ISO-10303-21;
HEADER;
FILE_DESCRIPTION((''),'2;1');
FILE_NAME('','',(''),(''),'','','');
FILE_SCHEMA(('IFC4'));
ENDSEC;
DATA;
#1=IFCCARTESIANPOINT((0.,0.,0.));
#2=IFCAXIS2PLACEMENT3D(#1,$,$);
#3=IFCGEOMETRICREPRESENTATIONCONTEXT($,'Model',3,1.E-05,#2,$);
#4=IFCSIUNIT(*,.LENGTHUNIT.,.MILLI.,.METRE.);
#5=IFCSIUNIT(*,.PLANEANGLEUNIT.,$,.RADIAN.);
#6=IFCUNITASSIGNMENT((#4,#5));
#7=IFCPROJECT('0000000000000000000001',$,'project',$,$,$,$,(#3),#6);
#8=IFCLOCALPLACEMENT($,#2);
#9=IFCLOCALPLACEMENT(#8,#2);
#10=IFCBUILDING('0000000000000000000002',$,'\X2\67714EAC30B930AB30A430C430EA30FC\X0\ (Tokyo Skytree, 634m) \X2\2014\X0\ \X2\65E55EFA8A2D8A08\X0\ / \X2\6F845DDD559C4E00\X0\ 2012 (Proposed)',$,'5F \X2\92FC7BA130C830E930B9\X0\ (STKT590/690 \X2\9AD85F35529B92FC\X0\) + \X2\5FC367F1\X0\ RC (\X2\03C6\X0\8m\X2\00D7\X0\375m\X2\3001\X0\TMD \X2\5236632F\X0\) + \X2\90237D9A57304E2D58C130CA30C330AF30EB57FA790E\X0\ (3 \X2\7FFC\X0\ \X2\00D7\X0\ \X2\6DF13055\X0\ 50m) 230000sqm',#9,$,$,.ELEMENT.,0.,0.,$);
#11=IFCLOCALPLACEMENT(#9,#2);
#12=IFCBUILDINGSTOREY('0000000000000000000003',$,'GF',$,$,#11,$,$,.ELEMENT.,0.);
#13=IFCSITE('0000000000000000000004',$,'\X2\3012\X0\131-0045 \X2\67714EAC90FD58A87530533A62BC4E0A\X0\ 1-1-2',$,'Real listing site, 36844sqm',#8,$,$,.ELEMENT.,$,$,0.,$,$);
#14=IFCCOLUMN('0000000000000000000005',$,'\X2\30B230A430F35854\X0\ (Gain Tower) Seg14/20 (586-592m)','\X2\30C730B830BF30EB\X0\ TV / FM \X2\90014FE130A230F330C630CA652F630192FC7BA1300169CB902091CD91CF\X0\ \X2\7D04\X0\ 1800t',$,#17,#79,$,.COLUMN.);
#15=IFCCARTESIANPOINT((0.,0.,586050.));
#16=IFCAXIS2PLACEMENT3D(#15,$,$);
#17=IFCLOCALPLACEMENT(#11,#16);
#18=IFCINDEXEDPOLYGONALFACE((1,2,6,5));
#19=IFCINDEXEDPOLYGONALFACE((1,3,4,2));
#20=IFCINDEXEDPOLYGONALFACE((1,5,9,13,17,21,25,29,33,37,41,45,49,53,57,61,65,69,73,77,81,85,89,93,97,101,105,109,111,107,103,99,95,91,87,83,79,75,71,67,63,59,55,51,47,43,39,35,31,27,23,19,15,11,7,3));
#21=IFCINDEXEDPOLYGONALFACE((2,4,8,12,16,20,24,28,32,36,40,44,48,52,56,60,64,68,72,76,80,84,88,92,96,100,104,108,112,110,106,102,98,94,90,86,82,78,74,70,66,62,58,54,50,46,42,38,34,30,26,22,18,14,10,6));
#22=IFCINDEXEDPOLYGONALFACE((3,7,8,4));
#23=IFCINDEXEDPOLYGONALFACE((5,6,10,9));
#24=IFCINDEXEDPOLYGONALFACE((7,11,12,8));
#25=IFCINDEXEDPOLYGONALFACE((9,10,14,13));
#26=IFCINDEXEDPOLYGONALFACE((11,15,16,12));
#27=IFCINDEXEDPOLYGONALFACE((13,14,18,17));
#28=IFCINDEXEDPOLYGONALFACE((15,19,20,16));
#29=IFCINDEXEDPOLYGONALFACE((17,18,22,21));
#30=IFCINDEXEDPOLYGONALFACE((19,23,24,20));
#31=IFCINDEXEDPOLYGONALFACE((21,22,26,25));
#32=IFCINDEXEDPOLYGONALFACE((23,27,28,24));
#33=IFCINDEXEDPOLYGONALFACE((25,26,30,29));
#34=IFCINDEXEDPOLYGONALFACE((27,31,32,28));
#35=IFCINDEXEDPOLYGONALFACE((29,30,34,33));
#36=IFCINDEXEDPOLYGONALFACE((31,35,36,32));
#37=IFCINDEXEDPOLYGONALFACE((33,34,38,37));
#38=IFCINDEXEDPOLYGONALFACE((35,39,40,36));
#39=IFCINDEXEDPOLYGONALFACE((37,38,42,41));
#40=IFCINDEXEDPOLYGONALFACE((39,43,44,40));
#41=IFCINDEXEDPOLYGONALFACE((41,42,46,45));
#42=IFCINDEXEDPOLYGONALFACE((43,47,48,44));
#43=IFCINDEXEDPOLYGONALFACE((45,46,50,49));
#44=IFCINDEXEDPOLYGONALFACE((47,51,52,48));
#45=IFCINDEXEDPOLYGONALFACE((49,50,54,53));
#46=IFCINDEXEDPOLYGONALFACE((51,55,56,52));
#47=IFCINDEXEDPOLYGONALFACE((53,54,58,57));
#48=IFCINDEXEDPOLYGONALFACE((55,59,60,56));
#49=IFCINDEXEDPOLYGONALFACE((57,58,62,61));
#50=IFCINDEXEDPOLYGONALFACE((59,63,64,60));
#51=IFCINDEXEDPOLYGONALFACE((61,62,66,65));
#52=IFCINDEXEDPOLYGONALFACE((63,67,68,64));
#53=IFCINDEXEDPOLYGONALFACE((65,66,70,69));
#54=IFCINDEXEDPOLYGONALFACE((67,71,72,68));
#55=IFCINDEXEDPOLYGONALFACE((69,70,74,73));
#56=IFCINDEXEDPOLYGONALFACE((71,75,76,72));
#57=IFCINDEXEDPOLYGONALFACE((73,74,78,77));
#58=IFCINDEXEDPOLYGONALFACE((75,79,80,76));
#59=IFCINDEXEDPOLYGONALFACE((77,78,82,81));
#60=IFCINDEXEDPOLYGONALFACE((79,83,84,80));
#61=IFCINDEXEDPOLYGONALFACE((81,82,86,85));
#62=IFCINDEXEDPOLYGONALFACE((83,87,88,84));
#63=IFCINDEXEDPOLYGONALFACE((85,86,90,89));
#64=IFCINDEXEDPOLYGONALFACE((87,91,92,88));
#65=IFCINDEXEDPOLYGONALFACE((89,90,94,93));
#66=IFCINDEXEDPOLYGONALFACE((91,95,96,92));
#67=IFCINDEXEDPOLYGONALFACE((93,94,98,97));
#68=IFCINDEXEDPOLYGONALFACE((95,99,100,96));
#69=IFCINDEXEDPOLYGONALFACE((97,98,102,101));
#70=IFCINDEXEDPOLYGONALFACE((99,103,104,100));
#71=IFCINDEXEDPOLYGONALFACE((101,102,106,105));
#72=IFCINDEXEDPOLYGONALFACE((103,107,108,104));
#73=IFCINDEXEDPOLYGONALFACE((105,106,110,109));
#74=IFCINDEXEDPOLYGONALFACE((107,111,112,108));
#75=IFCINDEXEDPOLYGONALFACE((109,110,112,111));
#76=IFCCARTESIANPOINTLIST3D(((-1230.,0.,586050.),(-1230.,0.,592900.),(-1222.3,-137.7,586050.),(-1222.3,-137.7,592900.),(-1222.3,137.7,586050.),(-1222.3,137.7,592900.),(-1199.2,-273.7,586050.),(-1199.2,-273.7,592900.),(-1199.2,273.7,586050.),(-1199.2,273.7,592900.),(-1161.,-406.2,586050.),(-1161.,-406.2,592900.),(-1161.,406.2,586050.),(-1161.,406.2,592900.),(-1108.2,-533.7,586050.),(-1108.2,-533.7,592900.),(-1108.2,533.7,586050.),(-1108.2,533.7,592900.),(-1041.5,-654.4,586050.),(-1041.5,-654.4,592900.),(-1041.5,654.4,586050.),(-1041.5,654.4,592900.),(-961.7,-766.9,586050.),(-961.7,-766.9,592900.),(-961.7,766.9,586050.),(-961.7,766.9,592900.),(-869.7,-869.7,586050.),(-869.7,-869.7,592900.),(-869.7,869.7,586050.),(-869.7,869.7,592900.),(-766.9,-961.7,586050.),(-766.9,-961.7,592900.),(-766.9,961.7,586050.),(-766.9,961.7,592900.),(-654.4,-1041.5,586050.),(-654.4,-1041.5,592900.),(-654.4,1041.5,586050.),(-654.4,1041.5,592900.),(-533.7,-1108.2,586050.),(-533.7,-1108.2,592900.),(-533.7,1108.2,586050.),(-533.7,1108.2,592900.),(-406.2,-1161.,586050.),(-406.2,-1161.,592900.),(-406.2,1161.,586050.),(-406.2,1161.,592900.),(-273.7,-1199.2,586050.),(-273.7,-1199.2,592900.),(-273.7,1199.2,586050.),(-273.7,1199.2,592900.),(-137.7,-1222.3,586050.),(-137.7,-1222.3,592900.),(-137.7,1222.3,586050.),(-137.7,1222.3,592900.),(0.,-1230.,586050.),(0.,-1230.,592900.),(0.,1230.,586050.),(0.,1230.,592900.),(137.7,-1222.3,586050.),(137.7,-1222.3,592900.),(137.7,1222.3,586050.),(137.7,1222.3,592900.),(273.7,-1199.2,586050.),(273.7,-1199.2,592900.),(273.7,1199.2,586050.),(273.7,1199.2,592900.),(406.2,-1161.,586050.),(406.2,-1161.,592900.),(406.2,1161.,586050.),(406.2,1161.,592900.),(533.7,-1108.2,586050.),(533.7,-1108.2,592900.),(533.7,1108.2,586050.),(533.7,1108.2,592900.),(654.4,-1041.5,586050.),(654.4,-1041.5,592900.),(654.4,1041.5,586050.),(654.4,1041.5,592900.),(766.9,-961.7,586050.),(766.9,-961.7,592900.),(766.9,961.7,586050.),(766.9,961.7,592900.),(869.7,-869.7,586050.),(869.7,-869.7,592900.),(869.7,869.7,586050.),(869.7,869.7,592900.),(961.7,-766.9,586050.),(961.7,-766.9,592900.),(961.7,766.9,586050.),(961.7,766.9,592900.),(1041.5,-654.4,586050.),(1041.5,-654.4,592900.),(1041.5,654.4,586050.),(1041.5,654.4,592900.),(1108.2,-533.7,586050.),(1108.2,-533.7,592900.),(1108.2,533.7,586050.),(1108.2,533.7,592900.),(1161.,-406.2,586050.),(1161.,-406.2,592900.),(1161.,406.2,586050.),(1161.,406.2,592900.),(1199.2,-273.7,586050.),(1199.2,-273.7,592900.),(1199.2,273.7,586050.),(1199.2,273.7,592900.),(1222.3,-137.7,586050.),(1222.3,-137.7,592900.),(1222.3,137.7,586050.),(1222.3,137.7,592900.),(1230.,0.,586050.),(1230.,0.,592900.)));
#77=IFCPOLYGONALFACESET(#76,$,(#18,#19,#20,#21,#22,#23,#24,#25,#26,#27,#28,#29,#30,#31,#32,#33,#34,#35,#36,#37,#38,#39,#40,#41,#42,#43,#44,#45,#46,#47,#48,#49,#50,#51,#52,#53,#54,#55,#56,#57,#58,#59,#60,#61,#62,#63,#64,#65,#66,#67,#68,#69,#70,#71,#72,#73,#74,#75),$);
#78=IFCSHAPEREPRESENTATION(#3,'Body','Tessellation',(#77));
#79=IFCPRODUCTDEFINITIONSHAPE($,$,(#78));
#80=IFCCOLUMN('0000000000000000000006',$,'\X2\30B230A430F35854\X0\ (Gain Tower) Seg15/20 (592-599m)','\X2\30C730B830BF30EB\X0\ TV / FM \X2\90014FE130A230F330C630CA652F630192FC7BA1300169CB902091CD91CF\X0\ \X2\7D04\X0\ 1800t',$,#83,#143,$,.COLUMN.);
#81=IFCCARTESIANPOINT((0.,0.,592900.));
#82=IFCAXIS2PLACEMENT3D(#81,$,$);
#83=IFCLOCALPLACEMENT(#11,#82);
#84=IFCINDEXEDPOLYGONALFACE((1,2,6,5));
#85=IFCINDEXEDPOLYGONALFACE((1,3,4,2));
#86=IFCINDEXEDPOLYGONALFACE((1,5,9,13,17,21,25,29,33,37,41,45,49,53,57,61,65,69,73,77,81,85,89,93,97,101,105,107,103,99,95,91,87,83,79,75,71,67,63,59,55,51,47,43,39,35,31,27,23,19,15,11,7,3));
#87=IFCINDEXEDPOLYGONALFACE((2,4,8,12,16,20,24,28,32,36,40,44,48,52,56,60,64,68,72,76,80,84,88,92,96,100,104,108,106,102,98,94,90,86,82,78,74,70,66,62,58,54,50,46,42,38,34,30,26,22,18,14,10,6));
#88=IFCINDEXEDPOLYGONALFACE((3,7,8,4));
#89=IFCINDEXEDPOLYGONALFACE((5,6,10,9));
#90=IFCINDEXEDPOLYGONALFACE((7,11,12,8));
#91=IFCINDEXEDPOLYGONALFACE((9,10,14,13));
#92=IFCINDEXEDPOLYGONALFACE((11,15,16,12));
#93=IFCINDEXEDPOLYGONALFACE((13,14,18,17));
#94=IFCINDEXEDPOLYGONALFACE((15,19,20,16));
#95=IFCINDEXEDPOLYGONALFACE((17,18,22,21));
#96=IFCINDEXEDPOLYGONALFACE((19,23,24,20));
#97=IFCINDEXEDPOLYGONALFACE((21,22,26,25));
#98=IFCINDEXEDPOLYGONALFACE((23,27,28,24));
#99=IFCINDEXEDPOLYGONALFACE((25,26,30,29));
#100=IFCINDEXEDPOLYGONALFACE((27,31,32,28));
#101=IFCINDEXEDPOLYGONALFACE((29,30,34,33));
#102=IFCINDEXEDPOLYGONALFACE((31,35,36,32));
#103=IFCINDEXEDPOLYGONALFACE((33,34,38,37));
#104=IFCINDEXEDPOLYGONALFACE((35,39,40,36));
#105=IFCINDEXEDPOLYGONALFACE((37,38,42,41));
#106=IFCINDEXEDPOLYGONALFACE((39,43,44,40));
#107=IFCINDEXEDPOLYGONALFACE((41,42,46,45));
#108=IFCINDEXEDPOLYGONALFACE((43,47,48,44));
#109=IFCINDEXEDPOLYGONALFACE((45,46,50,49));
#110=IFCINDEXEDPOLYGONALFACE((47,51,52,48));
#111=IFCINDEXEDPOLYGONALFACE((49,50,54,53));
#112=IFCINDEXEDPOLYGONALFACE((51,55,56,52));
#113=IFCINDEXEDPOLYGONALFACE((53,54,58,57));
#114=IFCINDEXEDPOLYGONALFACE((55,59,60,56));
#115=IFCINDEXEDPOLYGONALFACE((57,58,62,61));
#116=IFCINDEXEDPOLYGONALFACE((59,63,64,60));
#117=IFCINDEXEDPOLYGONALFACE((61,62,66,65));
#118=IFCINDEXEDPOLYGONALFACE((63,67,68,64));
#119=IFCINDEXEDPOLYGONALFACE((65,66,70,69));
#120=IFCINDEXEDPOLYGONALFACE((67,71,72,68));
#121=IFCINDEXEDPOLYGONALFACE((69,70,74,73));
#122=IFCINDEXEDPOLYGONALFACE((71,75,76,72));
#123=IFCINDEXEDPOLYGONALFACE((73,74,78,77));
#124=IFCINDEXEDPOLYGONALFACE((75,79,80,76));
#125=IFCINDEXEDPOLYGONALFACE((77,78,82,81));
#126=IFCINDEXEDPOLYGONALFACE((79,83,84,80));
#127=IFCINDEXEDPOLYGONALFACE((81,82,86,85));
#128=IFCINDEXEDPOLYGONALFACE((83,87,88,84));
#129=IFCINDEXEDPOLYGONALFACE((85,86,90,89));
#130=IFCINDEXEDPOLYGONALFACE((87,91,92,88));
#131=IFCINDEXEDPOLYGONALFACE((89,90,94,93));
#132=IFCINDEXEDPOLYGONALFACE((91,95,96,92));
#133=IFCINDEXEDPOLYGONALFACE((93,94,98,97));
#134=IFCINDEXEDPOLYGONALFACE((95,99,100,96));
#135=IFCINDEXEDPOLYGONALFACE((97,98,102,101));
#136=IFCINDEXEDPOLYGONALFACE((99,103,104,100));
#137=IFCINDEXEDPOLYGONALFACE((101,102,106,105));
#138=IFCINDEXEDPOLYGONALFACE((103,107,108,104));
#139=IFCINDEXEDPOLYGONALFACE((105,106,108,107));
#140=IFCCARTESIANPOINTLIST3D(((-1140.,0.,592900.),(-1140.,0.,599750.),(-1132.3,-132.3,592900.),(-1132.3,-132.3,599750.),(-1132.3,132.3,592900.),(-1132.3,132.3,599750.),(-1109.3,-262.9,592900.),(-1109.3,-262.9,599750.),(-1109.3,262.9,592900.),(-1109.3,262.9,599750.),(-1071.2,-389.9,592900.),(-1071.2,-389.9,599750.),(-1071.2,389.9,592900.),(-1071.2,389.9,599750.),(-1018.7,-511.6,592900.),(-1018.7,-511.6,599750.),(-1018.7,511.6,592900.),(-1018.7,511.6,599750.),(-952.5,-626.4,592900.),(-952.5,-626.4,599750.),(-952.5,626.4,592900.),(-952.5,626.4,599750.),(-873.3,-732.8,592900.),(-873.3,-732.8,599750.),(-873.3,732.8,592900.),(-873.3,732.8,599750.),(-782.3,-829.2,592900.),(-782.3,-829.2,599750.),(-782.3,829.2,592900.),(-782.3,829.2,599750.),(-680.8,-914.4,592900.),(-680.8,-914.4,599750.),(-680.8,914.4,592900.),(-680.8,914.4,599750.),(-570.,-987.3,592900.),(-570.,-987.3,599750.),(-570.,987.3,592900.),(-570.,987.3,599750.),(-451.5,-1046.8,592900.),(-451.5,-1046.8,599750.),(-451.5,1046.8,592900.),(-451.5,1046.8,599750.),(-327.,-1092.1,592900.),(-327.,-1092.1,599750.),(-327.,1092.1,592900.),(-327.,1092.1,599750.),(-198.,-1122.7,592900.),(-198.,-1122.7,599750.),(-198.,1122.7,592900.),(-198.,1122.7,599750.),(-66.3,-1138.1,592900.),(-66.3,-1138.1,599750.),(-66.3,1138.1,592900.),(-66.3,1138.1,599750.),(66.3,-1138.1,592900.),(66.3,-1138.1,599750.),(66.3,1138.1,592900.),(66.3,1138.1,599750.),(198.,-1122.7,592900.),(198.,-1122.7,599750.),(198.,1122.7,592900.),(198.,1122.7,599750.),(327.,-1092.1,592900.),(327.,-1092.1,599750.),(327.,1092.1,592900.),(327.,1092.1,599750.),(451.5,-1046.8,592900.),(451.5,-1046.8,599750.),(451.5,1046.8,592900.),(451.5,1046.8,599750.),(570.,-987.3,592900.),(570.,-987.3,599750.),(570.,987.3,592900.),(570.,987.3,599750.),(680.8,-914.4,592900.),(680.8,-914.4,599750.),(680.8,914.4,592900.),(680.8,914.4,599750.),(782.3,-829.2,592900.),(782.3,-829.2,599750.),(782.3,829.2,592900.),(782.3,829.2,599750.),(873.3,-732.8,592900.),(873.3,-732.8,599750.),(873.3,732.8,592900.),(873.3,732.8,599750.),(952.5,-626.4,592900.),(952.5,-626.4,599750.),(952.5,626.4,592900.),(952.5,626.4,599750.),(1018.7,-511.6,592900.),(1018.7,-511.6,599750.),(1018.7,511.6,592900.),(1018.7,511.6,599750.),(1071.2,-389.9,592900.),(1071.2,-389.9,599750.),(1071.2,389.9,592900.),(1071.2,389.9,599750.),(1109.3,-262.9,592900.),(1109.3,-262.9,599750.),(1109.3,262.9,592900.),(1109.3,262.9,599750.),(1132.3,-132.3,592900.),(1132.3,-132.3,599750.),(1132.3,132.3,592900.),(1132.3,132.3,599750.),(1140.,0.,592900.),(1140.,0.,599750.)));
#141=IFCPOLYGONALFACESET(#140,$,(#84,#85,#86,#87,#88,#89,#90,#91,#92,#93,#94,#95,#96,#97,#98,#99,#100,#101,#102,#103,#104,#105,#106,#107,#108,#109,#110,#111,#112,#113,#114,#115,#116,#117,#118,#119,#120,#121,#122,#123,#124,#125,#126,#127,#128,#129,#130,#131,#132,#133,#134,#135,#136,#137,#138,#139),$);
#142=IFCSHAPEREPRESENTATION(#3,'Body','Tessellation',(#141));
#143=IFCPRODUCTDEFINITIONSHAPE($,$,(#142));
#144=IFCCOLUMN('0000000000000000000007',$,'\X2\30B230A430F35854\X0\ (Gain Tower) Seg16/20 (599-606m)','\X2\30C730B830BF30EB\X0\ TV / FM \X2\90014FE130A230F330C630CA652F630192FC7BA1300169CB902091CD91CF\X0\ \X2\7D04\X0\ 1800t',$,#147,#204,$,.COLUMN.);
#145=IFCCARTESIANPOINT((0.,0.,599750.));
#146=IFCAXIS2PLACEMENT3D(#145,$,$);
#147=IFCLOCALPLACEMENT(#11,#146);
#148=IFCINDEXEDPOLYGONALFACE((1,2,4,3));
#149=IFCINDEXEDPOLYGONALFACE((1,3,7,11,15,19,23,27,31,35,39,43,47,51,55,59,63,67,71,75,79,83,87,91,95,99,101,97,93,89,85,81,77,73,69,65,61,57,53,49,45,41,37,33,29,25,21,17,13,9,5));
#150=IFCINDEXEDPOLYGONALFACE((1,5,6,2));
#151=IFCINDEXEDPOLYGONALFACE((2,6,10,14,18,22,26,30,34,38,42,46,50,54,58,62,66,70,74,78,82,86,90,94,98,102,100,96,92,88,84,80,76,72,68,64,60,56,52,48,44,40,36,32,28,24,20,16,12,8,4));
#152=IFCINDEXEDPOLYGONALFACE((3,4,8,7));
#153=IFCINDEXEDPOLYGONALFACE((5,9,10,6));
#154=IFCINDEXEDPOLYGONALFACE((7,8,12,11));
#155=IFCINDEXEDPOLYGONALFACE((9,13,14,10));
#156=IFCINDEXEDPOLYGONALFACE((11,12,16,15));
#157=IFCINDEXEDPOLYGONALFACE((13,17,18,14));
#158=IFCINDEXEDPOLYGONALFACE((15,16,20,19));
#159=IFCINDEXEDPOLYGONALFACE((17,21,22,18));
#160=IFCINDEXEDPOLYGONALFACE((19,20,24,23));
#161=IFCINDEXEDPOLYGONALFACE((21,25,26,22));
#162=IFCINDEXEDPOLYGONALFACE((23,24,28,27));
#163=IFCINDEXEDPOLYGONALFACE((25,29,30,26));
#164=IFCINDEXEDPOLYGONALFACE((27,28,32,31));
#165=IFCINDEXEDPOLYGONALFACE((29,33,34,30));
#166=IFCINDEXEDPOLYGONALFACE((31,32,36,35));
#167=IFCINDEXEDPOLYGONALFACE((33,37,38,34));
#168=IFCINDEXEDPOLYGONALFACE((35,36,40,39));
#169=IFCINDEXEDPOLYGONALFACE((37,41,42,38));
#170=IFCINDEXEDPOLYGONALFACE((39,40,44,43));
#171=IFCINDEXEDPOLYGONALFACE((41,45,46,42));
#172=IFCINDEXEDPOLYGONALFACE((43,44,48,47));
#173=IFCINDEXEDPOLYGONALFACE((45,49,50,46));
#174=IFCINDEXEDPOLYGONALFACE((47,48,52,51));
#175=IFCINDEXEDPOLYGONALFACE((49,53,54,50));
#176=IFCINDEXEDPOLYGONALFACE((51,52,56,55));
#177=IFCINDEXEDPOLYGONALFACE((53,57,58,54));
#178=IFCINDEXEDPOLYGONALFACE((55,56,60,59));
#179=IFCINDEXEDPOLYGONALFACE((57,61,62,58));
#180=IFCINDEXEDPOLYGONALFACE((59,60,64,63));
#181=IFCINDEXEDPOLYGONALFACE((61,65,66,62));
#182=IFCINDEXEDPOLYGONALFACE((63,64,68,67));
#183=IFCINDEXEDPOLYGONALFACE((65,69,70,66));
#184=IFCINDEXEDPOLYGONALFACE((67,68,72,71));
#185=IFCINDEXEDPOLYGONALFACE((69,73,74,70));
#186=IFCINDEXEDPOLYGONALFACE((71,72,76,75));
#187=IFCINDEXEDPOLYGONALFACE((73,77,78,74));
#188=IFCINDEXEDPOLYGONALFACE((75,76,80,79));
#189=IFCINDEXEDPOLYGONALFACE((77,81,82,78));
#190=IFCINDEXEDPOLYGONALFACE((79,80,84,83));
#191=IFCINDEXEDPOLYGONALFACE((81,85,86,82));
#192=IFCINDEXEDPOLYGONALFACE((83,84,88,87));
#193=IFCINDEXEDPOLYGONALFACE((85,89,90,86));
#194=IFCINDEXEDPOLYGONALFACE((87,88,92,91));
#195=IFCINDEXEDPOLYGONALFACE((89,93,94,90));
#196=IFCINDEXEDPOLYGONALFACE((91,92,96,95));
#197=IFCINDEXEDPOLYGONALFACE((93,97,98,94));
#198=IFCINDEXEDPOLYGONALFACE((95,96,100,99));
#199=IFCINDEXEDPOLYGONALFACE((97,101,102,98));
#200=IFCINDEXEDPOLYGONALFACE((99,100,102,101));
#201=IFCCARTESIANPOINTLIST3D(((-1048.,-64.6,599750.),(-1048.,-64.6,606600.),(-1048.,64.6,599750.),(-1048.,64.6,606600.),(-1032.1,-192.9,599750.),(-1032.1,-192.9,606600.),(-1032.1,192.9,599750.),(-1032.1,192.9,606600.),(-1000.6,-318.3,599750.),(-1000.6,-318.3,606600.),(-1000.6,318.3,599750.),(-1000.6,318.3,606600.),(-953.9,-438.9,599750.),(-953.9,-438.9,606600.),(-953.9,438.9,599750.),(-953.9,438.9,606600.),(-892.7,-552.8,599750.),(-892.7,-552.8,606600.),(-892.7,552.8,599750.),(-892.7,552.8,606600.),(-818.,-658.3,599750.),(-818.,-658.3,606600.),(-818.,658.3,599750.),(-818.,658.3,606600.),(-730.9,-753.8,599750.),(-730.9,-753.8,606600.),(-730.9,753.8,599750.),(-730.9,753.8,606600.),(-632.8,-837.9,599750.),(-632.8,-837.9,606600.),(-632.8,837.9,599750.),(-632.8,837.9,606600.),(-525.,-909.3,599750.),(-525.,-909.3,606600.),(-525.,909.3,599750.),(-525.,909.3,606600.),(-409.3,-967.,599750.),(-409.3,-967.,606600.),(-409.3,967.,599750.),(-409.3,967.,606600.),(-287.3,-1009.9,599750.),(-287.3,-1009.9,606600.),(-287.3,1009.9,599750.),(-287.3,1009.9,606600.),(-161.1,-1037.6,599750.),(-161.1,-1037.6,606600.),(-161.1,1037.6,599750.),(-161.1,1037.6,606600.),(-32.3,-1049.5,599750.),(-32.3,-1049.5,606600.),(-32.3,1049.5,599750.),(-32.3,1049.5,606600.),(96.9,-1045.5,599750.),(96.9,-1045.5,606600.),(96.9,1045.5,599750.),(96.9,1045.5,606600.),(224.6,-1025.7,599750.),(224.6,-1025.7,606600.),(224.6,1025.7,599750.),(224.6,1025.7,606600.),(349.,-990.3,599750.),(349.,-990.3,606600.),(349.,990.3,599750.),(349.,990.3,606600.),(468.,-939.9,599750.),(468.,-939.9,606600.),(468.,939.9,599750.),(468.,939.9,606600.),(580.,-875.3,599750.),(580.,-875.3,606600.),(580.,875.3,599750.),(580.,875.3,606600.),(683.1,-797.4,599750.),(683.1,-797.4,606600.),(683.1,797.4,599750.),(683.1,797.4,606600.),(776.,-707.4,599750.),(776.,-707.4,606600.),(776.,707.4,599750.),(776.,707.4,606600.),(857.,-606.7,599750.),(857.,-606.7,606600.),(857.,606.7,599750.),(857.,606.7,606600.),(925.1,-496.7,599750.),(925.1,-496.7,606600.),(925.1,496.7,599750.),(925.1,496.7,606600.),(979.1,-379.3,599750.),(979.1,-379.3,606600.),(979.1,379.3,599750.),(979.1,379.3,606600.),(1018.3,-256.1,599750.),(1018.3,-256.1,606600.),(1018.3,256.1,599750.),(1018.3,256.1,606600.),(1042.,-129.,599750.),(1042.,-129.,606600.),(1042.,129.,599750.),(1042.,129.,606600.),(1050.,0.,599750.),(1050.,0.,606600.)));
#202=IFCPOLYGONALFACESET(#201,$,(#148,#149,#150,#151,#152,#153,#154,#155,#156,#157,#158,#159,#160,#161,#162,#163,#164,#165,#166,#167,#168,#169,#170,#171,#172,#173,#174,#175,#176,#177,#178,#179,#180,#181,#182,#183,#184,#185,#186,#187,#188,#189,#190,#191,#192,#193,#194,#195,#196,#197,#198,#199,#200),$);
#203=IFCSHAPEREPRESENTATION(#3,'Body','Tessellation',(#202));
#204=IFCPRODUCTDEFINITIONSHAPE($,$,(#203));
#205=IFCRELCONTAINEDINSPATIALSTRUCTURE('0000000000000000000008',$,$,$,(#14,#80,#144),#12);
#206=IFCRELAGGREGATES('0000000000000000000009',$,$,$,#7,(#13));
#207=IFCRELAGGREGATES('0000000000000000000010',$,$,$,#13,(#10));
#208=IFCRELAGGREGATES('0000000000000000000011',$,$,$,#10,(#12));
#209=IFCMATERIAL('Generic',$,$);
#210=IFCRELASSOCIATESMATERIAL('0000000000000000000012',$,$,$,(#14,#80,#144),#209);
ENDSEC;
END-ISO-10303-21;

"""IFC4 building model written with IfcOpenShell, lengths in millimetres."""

from ifc_helpers import new_model, si_unit, frame, origin, origin_2d, place, context, project, spatial, circle, extrude, material, element, save


model = new_model("IFC4")

# Units and contexts
model_context = context("Model", 3, precision=1e-05, world=origin())
ifc_project = project(units=[si_unit("LENGTHUNIT", "METRE", prefix="MILLI"), si_unit("PLANEANGLEUNIT", "RADIAN")], contexts=[model_context])

# Site, building, storey
site_placement = place(None, origin())
site = spatial("IfcSite", under=ifc_project, at=site_placement, Name="〒131-0045 東京都墨田区押上 1-1-2", ObjectType="Real listing site, 36844sqm", CompositionType="ELEMENT", RefElevation=0.0)
building_placement = place(site_placement, origin())
building = spatial("IfcBuilding", under=site, at=building_placement, Name="東京スカイツリー (Tokyo Skytree, 634m) — 日建設計 / 澄川喜一 2012 (Proposed)", ObjectType="5F 鋼管トラス (STKT590/690 高張力鋼) + 心柱 RC (φ8m×375m、TMD 制振) + 連続地中壁ナックル基礎 (3 翼 × 深さ 50m) 230000sqm", CompositionType="ELEMENT", ElevationOfRefHeight=0.0, ElevationOfTerrain=0.0)
storey_placement = place(building_placement, origin())
storey = spatial("IfcBuildingStorey", under=building, at=storey_placement, Name="GF", CompositionType="ELEMENT", Elevation=0.0)

# Columns
ifc_material = material(Name="Generic")
column_1_placement = place(storey_placement, frame((0.0, 0.0, 586050.0)))
element("IfcColumn", 1, at=column_1_placement, inside=storey, material=ifc_material, Name="ゲイン塔 (Gain Tower) Seg14/20 (586-592m)", Description="デジタル TV / FM 送信アンテナ支持鋼管、構造重量 約 1800t", PredefinedType="COLUMN", context=model_context, shape_type="SweptSolid", body=[
    extrude(circle(Radius=1230.0, at=origin_2d()), frame((0.0, 0.0, 586050.0)), (0.0, 0.0, 1.0), 6850.0),
])
column_2_placement = place(storey_placement, frame((0.0, 0.0, 592900.0)))
element("IfcColumn", 2, at=column_2_placement, inside=storey, material=ifc_material, Name="ゲイン塔 (Gain Tower) Seg15/20 (592-599m)", Description="デジタル TV / FM 送信アンテナ支持鋼管、構造重量 約 1800t", PredefinedType="COLUMN", context=model_context, shape_type="SweptSolid", body=[
    extrude(circle(Radius=1140.0, at=origin_2d()), frame((0.0, 0.0, 592900.0)), (0.0, 0.0, 1.0), 6850.0),
])
column_3_placement = place(storey_placement, frame((0.0, 0.0, 599750.0)))
element("IfcColumn", 3, at=column_3_placement, inside=storey, material=ifc_material, Name="ゲイン塔 (Gain Tower) Seg16/20 (599-606m)", Description="デジタル TV / FM 送信アンテナ支持鋼管、構造重量 約 1800t", PredefinedType="COLUMN", context=model_context, shape_type="SweptSolid", body=[
    extrude(circle(Radius=1050.0, at=origin_2d()), frame((0.0, 0.0, 599750.0)), (0.0, 0.0, 1.0), 6850.0),
])

save(model, "model.ifc")
